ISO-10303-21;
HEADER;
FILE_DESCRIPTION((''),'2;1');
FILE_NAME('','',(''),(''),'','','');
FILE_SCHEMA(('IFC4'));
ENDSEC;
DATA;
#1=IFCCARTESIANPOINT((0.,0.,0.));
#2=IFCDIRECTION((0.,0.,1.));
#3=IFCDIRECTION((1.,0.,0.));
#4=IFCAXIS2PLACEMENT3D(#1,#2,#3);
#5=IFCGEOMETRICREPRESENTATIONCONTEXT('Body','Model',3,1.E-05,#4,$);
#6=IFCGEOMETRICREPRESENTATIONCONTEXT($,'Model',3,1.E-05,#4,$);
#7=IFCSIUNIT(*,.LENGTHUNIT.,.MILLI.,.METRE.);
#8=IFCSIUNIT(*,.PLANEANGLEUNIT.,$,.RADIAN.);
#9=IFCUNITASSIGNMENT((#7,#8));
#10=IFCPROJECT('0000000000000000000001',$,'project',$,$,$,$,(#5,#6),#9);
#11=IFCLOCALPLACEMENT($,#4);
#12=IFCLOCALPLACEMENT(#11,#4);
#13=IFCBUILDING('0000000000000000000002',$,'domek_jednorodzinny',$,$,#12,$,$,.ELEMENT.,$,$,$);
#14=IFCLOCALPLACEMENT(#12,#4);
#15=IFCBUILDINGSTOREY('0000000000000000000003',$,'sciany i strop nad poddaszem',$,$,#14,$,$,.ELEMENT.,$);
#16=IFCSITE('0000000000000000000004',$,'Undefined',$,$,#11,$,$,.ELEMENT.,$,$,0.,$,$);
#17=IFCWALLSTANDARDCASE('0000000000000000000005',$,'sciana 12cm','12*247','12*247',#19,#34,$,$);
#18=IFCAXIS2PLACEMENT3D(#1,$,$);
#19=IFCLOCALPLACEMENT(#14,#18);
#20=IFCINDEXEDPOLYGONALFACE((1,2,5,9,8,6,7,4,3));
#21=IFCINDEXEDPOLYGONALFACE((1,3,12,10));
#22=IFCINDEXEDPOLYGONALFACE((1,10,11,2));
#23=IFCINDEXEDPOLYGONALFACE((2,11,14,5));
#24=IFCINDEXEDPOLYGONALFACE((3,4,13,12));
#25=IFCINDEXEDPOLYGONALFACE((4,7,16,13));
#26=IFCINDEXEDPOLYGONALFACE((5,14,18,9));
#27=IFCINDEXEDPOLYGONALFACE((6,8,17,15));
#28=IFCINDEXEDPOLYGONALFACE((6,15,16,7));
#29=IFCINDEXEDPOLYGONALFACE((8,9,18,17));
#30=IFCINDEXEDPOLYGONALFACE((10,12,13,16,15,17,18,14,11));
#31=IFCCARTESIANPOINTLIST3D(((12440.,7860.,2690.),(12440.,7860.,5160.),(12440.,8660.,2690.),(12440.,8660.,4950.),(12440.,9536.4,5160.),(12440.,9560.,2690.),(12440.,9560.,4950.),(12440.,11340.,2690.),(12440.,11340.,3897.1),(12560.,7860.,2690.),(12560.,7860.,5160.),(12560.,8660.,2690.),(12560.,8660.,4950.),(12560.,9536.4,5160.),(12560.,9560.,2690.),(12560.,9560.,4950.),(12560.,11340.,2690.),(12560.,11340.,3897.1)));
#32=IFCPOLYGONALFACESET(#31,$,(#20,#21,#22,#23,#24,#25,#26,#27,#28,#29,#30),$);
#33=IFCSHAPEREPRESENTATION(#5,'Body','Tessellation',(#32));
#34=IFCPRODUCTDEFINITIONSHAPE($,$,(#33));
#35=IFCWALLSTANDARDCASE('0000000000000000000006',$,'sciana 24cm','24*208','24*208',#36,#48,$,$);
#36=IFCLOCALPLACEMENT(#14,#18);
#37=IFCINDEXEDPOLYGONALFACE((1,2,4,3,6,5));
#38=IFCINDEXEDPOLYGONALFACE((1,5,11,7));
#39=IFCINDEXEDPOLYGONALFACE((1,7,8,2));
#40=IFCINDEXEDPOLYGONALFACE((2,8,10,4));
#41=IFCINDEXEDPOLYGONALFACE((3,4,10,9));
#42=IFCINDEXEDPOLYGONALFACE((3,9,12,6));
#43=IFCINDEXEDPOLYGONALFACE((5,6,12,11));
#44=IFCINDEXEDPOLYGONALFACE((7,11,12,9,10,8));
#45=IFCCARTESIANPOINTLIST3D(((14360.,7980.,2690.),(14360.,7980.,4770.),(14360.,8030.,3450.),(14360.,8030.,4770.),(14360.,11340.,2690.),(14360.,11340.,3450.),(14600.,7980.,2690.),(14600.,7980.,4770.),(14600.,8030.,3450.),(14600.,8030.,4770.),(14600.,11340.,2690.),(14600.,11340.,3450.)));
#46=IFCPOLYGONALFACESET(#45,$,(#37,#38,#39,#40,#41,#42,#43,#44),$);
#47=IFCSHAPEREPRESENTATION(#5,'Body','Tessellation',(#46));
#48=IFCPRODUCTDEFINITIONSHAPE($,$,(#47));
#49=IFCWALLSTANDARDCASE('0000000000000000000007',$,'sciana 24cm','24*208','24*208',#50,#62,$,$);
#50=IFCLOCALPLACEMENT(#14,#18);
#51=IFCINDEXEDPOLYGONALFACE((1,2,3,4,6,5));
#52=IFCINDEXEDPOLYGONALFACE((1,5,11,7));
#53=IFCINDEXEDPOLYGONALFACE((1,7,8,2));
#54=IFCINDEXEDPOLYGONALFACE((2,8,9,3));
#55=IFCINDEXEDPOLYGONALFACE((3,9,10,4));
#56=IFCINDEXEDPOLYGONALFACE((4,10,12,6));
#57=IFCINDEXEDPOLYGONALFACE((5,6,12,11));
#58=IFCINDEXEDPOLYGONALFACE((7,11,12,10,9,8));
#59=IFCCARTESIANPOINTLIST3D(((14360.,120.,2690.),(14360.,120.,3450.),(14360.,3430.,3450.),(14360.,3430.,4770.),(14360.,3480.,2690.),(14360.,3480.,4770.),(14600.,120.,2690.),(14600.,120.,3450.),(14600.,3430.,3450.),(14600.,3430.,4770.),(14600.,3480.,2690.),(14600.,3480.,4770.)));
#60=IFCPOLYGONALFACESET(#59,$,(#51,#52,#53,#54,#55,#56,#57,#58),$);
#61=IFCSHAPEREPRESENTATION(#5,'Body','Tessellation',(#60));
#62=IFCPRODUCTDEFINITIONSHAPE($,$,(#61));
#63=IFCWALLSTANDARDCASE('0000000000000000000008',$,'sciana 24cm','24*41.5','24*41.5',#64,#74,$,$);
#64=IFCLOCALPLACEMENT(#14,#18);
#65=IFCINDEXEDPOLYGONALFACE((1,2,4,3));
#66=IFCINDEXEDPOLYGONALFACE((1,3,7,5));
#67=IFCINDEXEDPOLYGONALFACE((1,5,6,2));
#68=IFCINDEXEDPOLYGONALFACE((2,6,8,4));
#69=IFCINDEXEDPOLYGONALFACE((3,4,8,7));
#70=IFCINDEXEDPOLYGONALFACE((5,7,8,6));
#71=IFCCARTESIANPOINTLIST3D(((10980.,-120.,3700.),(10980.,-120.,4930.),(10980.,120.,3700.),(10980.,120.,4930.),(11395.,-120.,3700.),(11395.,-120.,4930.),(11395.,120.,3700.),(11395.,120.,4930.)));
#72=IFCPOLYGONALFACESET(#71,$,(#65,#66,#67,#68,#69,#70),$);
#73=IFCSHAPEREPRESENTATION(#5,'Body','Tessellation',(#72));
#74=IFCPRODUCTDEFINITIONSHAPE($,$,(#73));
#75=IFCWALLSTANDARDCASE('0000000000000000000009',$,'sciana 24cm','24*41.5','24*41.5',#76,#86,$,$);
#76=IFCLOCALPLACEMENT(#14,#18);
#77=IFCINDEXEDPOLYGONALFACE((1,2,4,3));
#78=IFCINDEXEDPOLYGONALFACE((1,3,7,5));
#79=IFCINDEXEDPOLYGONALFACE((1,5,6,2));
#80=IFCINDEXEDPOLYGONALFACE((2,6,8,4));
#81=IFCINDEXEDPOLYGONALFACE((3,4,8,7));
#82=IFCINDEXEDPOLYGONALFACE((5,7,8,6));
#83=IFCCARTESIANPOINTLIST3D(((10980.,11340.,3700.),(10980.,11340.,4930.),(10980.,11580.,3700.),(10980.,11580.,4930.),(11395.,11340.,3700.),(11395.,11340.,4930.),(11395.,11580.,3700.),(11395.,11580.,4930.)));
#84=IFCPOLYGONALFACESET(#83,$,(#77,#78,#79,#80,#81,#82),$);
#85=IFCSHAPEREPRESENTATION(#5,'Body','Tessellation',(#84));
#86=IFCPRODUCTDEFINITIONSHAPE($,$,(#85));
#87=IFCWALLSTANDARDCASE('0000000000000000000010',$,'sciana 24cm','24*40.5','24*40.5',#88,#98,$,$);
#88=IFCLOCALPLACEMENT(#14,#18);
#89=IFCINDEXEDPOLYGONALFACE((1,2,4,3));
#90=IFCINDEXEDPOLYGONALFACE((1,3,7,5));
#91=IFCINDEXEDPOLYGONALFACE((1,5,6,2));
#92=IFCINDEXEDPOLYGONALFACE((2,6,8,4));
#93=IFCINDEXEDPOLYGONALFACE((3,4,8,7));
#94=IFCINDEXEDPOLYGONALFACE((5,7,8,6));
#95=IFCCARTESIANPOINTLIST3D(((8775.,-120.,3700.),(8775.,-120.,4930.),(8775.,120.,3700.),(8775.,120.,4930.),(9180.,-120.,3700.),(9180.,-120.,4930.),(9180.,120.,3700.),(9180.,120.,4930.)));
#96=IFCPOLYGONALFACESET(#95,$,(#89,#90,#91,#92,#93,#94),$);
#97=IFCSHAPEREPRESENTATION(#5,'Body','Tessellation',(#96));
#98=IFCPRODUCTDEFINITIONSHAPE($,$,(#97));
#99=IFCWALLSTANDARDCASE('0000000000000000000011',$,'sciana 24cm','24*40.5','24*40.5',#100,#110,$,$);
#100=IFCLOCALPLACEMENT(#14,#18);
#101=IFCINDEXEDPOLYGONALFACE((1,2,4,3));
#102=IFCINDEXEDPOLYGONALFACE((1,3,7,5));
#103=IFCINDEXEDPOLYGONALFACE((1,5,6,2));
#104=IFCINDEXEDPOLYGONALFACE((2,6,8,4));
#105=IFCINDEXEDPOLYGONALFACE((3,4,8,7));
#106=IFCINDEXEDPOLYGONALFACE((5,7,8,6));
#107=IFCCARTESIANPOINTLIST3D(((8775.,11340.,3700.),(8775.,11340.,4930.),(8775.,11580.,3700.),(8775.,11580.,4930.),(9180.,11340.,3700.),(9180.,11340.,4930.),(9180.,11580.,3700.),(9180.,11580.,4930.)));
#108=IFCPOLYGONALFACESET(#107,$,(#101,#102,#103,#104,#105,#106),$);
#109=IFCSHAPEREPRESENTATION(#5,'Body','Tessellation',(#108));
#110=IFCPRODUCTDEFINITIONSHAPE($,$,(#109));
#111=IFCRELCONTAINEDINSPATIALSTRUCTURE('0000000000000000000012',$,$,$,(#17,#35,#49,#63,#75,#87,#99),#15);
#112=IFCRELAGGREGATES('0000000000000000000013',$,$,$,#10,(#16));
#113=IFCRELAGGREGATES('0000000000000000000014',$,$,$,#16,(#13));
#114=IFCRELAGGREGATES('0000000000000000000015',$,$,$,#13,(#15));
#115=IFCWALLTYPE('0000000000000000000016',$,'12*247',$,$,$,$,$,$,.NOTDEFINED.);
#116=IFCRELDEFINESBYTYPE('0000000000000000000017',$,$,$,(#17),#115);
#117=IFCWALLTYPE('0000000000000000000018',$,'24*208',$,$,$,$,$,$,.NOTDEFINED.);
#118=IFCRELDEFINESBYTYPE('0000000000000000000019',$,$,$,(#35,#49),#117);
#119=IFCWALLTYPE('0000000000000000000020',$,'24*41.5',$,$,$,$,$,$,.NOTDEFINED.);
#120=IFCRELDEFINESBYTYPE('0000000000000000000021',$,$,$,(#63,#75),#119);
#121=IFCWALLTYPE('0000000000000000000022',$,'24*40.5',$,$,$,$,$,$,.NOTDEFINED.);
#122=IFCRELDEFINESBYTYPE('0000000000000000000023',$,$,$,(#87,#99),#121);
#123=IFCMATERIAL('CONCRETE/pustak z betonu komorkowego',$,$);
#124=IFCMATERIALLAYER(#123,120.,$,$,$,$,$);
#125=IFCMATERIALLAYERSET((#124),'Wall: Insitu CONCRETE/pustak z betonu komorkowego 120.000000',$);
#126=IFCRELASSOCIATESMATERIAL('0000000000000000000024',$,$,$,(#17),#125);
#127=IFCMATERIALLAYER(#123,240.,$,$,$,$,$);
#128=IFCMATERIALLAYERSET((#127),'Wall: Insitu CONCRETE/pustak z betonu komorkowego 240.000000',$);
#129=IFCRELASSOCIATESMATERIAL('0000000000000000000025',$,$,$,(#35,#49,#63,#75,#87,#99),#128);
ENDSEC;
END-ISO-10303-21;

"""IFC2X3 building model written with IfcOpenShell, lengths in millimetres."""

from ifc_helpers import new_model, si_unit, frame, frame_2d, origin_with_axes, place, context, project, spatial, polyline, rectangle, outline, extrude, clip, halfspace, material, layer, layer_set, layer_usage, type_object, element, save


model = new_model("IFC2X3")

# Units and contexts
model_context_1 = context("Model", 3, precision=1e-05, world=origin_with_axes(), identifier="Body")
model_context_2 = context("Model", 3, precision=1e-05, world=origin_with_axes())
ifc_project = project(units=[si_unit("LENGTHUNIT", "METRE", prefix="MILLI"), si_unit("PLANEANGLEUNIT", "RADIAN")], contexts=[model_context_1, model_context_2])

# Site, building, storey
site_placement = place(None, origin_with_axes())
site = spatial("IfcSite", under=ifc_project, at=site_placement, Name="Undefined", CompositionType="ELEMENT", RefElevation=0.0)
building_placement = place(site_placement, origin_with_axes())
building = spatial("IfcBuilding", under=site, at=building_placement, Name="domek_jednorodzinny", CompositionType="ELEMENT")
storey_placement = place(building_placement, origin_with_axes())
storey = spatial("IfcBuildingStorey", under=building, at=storey_placement, Name="sciany i strop nad poddaszem", CompositionType="ELEMENT")

# Shared definitions
ifc_material_1 = material(Name="CONCRETE/pustak z betonu komorkowego")
ifc_layer_1 = layer(ifc_material_1, 120.0)
ifc_layer_set_1 = layer_set([ifc_layer_1], Name="Wall: Insitu CONCRETE/pustak z betonu komorkowego 120.000000")

# Shared definitions
ifc_layer_2 = layer(ifc_material_1, 240.0)
ifc_layer_set_2 = layer_set([ifc_layer_2], Name="Wall: Insitu CONCRETE/pustak z betonu komorkowego 240.000000")

# Walls, openings
ifc_layer_usage_1 = layer_usage(ifc_layer_set_1, "AXIS2", "POSITIVE", -60.0)
wall_type_1 = type_object("IfcWallType", Name="12*247", PredefinedType="NOTDEFINED")
wall_1_placement = place(storey_placement, frame((12500.0, 7860.0, 2690.0), z_axis=(0.0, 0.0, 1.0), x_axis=(0.0, 1.0, 0.0)))
wall_1 = element("IfcWallStandardCase", 1, at=wall_1_placement, inside=storey, type_object=wall_type_1, material=ifc_layer_usage_1, Name="sciana 12cm", Description="12*247", ObjectType="12*247", context=model_context_1, shape_type="Clipping", body=[
    clip(extrude(rectangle(XDim=3480.0, YDim=120.0, at=frame_2d((0.0, 1740.0), x_axis=(0.0, -1.0))), frame((0.0, 0.0, 0.0), z_axis=(0.0, 0.0, 1.0), x_axis=(0.0, -1.0, 0.0)), (0.0, 0.0, 1.0), 2470.0), halfspace(frame((5239.6, -60.0, -25.0), z_axis=(0.573578, 0.0, 0.819151), x_axis=(-0.819152, 0.0, 0.573576)), False)),
])
opening_1_placement = place(storey_placement, frame((12500.0, 7860.0, 2690.0), z_axis=(0.0, 0.0, 1.0), x_axis=(0.0, 1.0, 0.0)))
element("IfcOpeningElement", 2, at=opening_1_placement, cuts=wall_1, ObjectType="Recess", context=model_context_1, shape_type="SweptSolid", body=[
    extrude(outline(polyline([(0.0, 0.0), (360.0, 0.0), (360.0, 900.0), (0.0, 900.0), (0.0, 0.0)])), frame((800.0, -180.0, 2260.0), z_axis=(0.000001, 0.000001, -1.0), x_axis=(0.0, 1.0, 0.0)), (0.0, 0.0, 1.0), 2260.0),
])
ifc_layer_usage_2 = layer_usage(ifc_layer_set_2, "AXIS2", "POSITIVE", -120.0)
wall_type_2 = type_object("IfcWallType", Name="24*208", PredefinedType="NOTDEFINED")
wall_2_placement = place(storey_placement, frame((14480.0, 7980.0, 2690.0), z_axis=(0.0, 0.0, 1.0), x_axis=(0.0, 1.0, 0.0)))
wall_2 = element("IfcWallStandardCase", 3, at=wall_2_placement, inside=storey, type_object=wall_type_2, material=ifc_layer_usage_2, Name="sciana 24cm", Description="24*208", ObjectType="24*208", context=model_context_1, shape_type="SweptSolid", body=[
    extrude(rectangle(XDim=3360.0, YDim=240.0, at=frame_2d((0.0, 1680.0), x_axis=(0.0, -1.0))), frame((0.0, 0.0, 0.0), z_axis=(0.0, 0.0, 1.0), x_axis=(0.0, -1.0, 0.0)), (0.0, 0.0, 1.0), 2080.0),
])
opening_2_placement = place(storey_placement, frame((14480.0, 7980.0, 2690.0), z_axis=(0.0, 0.0, 1.0), x_axis=(0.0, 1.0, 0.0)))
element("IfcOpeningElement", 4, at=opening_2_placement, cuts=wall_2, ObjectType="Recess", context=model_context_1, shape_type="SweptSolid", body=[
    extrude(outline(polyline([(0.0, 0.0), (1700.0, 0.0), (1700.0, 3310.0), (0.0, 3310.0), (0.0, 0.0)])), frame((50.0, -203.0, 760.0), z_axis=(0.0, 1.0, 0.0), x_axis=(0.0, 0.0, 1.0)), (0.0, 0.0, 1.0), 406.0),
])
ifc_layer_usage_3 = layer_usage(ifc_layer_set_2, "AXIS2", "POSITIVE", -120.0)
wall_3_placement = place(storey_placement, frame((14480.0, 120.0, 2690.0), z_axis=(0.0, 0.0, 1.0), x_axis=(0.0, 1.0, 0.0)))
wall_3 = element("IfcWallStandardCase", 5, at=wall_3_placement, inside=storey, type_object=wall_type_2, material=ifc_layer_usage_3, Name="sciana 24cm", Description="24*208", ObjectType="24*208", context=model_context_1, shape_type="SweptSolid", body=[
    extrude(rectangle(XDim=3360.0, YDim=240.0, at=frame_2d((0.0, 1680.0), x_axis=(0.0, -1.0))), frame((0.0, 0.0, 0.0), z_axis=(0.0, 0.0, 1.0), x_axis=(0.0, -1.0, 0.0)), (0.0, 0.0, 1.0), 2080.0),
])
opening_3_placement = place(storey_placement, frame((14480.0, 120.0, 2690.0), z_axis=(0.0, 0.0, 1.0), x_axis=(0.0, 1.0, 0.0)))
element("IfcOpeningElement", 6, at=opening_3_placement, cuts=wall_3, ObjectType="Recess", context=model_context_1, shape_type="SweptSolid", body=[
    extrude(outline(polyline([(0.0, 0.0), (1700.0, 0.0), (1700.0, 3310.0), (0.0, 3310.0), (0.0, 0.0)])), frame((3310.0, 153.0, 760.0), z_axis=(0.0, -1.0, 0.0), x_axis=(0.0, 0.0, 1.0)), (0.0, 0.0, 1.0), 306.0),
])

# Walls
ifc_layer_usage_4 = layer_usage(ifc_layer_set_2, "AXIS2", "POSITIVE", -120.0)
wall_type_3 = type_object("IfcWallType", Name="24*41.5", PredefinedType="NOTDEFINED")
wall_4_placement = place(storey_placement, frame((10980.0, 0.0, 3700.0), z_axis=(0.0, 0.0, 1.0), x_axis=(1.0, 0.0, 0.0)))
element("IfcWallStandardCase", 7, at=wall_4_placement, inside=storey, type_object=wall_type_3, material=ifc_layer_usage_4, Name="sciana 24cm", Description="24*41.5", ObjectType="24*41.5", context=model_context_1, shape_type="SweptSolid", body=[
    extrude(rectangle(XDim=415.0, YDim=240.0, at=frame_2d((0.0, 207.5), x_axis=(0.0, -1.0))), frame((0.0, 0.0, 0.0), z_axis=(0.0, 0.0, 1.0), x_axis=(0.0, -1.0, 0.0)), (0.0, 0.0, 1.0), 1230.0),
])
ifc_layer_usage_5 = layer_usage(ifc_layer_set_2, "AXIS2", "POSITIVE", -120.0)
wall_5_placement = place(storey_placement, frame((10980.0, 11460.0, 3700.0), z_axis=(0.0, 0.0, 1.0), x_axis=(1.0, 0.0, 0.0)))
element("IfcWallStandardCase", 8, at=wall_5_placement, inside=storey, type_object=wall_type_3, material=ifc_layer_usage_5, Name="sciana 24cm", Description="24*41.5", ObjectType="24*41.5", context=model_context_1, shape_type="SweptSolid", body=[
    extrude(rectangle(XDim=415.0, YDim=240.0, at=frame_2d((0.0, 207.5), x_axis=(0.0, -1.0))), frame((0.0, 0.0, 0.0), z_axis=(0.0, 0.0, 1.0), x_axis=(0.0, -1.0, 0.0)), (0.0, 0.0, 1.0), 1230.0),
])
ifc_layer_usage_6 = layer_usage(ifc_layer_set_2, "AXIS2", "POSITIVE", -120.0)
wall_type_4 = type_object("IfcWallType", Name="24*40.5", PredefinedType="NOTDEFINED")
wall_6_placement = place(storey_placement, frame((8775.0, 0.0, 3700.0), z_axis=(0.0, 0.0, 1.0), x_axis=(1.0, 0.0, 0.0)))
element("IfcWallStandardCase", 9, at=wall_6_placement, inside=storey, type_object=wall_type_4, material=ifc_layer_usage_6, Name="sciana 24cm", Description="24*40.5", ObjectType="24*40.5", context=model_context_1, shape_type="SweptSolid", body=[
    extrude(rectangle(XDim=405.0, YDim=240.0, at=frame_2d((0.0, 202.5), x_axis=(0.0, -1.0))), frame((0.0, 0.0, 0.0), z_axis=(0.0, 0.0, 1.0), x_axis=(0.0, -1.0, 0.0)), (0.0, 0.0, 1.0), 1230.0),
])
ifc_layer_usage_7 = layer_usage(ifc_layer_set_2, "AXIS2", "POSITIVE", -120.0)
wall_7_placement = place(storey_placement, frame((8775.0, 11460.0, 3700.0), z_axis=(0.0, 0.0, 1.0), x_axis=(1.0, 0.0, 0.0)))
element("IfcWallStandardCase", 10, at=wall_7_placement, inside=storey, type_object=wall_type_4, material=ifc_layer_usage_7, Name="sciana 24cm", Description="24*40.5", ObjectType="24*40.5", context=model_context_1, shape_type="SweptSolid", body=[
    extrude(rectangle(XDim=405.0, YDim=240.0, at=frame_2d((0.0, 202.5), x_axis=(0.0, -1.0))), frame((0.0, 0.0, 0.0), z_axis=(0.0, 0.0, 1.0), x_axis=(0.0, -1.0, 0.0)), (0.0, 0.0, 1.0), 1230.0),
])

save(model, "model.ifc")
